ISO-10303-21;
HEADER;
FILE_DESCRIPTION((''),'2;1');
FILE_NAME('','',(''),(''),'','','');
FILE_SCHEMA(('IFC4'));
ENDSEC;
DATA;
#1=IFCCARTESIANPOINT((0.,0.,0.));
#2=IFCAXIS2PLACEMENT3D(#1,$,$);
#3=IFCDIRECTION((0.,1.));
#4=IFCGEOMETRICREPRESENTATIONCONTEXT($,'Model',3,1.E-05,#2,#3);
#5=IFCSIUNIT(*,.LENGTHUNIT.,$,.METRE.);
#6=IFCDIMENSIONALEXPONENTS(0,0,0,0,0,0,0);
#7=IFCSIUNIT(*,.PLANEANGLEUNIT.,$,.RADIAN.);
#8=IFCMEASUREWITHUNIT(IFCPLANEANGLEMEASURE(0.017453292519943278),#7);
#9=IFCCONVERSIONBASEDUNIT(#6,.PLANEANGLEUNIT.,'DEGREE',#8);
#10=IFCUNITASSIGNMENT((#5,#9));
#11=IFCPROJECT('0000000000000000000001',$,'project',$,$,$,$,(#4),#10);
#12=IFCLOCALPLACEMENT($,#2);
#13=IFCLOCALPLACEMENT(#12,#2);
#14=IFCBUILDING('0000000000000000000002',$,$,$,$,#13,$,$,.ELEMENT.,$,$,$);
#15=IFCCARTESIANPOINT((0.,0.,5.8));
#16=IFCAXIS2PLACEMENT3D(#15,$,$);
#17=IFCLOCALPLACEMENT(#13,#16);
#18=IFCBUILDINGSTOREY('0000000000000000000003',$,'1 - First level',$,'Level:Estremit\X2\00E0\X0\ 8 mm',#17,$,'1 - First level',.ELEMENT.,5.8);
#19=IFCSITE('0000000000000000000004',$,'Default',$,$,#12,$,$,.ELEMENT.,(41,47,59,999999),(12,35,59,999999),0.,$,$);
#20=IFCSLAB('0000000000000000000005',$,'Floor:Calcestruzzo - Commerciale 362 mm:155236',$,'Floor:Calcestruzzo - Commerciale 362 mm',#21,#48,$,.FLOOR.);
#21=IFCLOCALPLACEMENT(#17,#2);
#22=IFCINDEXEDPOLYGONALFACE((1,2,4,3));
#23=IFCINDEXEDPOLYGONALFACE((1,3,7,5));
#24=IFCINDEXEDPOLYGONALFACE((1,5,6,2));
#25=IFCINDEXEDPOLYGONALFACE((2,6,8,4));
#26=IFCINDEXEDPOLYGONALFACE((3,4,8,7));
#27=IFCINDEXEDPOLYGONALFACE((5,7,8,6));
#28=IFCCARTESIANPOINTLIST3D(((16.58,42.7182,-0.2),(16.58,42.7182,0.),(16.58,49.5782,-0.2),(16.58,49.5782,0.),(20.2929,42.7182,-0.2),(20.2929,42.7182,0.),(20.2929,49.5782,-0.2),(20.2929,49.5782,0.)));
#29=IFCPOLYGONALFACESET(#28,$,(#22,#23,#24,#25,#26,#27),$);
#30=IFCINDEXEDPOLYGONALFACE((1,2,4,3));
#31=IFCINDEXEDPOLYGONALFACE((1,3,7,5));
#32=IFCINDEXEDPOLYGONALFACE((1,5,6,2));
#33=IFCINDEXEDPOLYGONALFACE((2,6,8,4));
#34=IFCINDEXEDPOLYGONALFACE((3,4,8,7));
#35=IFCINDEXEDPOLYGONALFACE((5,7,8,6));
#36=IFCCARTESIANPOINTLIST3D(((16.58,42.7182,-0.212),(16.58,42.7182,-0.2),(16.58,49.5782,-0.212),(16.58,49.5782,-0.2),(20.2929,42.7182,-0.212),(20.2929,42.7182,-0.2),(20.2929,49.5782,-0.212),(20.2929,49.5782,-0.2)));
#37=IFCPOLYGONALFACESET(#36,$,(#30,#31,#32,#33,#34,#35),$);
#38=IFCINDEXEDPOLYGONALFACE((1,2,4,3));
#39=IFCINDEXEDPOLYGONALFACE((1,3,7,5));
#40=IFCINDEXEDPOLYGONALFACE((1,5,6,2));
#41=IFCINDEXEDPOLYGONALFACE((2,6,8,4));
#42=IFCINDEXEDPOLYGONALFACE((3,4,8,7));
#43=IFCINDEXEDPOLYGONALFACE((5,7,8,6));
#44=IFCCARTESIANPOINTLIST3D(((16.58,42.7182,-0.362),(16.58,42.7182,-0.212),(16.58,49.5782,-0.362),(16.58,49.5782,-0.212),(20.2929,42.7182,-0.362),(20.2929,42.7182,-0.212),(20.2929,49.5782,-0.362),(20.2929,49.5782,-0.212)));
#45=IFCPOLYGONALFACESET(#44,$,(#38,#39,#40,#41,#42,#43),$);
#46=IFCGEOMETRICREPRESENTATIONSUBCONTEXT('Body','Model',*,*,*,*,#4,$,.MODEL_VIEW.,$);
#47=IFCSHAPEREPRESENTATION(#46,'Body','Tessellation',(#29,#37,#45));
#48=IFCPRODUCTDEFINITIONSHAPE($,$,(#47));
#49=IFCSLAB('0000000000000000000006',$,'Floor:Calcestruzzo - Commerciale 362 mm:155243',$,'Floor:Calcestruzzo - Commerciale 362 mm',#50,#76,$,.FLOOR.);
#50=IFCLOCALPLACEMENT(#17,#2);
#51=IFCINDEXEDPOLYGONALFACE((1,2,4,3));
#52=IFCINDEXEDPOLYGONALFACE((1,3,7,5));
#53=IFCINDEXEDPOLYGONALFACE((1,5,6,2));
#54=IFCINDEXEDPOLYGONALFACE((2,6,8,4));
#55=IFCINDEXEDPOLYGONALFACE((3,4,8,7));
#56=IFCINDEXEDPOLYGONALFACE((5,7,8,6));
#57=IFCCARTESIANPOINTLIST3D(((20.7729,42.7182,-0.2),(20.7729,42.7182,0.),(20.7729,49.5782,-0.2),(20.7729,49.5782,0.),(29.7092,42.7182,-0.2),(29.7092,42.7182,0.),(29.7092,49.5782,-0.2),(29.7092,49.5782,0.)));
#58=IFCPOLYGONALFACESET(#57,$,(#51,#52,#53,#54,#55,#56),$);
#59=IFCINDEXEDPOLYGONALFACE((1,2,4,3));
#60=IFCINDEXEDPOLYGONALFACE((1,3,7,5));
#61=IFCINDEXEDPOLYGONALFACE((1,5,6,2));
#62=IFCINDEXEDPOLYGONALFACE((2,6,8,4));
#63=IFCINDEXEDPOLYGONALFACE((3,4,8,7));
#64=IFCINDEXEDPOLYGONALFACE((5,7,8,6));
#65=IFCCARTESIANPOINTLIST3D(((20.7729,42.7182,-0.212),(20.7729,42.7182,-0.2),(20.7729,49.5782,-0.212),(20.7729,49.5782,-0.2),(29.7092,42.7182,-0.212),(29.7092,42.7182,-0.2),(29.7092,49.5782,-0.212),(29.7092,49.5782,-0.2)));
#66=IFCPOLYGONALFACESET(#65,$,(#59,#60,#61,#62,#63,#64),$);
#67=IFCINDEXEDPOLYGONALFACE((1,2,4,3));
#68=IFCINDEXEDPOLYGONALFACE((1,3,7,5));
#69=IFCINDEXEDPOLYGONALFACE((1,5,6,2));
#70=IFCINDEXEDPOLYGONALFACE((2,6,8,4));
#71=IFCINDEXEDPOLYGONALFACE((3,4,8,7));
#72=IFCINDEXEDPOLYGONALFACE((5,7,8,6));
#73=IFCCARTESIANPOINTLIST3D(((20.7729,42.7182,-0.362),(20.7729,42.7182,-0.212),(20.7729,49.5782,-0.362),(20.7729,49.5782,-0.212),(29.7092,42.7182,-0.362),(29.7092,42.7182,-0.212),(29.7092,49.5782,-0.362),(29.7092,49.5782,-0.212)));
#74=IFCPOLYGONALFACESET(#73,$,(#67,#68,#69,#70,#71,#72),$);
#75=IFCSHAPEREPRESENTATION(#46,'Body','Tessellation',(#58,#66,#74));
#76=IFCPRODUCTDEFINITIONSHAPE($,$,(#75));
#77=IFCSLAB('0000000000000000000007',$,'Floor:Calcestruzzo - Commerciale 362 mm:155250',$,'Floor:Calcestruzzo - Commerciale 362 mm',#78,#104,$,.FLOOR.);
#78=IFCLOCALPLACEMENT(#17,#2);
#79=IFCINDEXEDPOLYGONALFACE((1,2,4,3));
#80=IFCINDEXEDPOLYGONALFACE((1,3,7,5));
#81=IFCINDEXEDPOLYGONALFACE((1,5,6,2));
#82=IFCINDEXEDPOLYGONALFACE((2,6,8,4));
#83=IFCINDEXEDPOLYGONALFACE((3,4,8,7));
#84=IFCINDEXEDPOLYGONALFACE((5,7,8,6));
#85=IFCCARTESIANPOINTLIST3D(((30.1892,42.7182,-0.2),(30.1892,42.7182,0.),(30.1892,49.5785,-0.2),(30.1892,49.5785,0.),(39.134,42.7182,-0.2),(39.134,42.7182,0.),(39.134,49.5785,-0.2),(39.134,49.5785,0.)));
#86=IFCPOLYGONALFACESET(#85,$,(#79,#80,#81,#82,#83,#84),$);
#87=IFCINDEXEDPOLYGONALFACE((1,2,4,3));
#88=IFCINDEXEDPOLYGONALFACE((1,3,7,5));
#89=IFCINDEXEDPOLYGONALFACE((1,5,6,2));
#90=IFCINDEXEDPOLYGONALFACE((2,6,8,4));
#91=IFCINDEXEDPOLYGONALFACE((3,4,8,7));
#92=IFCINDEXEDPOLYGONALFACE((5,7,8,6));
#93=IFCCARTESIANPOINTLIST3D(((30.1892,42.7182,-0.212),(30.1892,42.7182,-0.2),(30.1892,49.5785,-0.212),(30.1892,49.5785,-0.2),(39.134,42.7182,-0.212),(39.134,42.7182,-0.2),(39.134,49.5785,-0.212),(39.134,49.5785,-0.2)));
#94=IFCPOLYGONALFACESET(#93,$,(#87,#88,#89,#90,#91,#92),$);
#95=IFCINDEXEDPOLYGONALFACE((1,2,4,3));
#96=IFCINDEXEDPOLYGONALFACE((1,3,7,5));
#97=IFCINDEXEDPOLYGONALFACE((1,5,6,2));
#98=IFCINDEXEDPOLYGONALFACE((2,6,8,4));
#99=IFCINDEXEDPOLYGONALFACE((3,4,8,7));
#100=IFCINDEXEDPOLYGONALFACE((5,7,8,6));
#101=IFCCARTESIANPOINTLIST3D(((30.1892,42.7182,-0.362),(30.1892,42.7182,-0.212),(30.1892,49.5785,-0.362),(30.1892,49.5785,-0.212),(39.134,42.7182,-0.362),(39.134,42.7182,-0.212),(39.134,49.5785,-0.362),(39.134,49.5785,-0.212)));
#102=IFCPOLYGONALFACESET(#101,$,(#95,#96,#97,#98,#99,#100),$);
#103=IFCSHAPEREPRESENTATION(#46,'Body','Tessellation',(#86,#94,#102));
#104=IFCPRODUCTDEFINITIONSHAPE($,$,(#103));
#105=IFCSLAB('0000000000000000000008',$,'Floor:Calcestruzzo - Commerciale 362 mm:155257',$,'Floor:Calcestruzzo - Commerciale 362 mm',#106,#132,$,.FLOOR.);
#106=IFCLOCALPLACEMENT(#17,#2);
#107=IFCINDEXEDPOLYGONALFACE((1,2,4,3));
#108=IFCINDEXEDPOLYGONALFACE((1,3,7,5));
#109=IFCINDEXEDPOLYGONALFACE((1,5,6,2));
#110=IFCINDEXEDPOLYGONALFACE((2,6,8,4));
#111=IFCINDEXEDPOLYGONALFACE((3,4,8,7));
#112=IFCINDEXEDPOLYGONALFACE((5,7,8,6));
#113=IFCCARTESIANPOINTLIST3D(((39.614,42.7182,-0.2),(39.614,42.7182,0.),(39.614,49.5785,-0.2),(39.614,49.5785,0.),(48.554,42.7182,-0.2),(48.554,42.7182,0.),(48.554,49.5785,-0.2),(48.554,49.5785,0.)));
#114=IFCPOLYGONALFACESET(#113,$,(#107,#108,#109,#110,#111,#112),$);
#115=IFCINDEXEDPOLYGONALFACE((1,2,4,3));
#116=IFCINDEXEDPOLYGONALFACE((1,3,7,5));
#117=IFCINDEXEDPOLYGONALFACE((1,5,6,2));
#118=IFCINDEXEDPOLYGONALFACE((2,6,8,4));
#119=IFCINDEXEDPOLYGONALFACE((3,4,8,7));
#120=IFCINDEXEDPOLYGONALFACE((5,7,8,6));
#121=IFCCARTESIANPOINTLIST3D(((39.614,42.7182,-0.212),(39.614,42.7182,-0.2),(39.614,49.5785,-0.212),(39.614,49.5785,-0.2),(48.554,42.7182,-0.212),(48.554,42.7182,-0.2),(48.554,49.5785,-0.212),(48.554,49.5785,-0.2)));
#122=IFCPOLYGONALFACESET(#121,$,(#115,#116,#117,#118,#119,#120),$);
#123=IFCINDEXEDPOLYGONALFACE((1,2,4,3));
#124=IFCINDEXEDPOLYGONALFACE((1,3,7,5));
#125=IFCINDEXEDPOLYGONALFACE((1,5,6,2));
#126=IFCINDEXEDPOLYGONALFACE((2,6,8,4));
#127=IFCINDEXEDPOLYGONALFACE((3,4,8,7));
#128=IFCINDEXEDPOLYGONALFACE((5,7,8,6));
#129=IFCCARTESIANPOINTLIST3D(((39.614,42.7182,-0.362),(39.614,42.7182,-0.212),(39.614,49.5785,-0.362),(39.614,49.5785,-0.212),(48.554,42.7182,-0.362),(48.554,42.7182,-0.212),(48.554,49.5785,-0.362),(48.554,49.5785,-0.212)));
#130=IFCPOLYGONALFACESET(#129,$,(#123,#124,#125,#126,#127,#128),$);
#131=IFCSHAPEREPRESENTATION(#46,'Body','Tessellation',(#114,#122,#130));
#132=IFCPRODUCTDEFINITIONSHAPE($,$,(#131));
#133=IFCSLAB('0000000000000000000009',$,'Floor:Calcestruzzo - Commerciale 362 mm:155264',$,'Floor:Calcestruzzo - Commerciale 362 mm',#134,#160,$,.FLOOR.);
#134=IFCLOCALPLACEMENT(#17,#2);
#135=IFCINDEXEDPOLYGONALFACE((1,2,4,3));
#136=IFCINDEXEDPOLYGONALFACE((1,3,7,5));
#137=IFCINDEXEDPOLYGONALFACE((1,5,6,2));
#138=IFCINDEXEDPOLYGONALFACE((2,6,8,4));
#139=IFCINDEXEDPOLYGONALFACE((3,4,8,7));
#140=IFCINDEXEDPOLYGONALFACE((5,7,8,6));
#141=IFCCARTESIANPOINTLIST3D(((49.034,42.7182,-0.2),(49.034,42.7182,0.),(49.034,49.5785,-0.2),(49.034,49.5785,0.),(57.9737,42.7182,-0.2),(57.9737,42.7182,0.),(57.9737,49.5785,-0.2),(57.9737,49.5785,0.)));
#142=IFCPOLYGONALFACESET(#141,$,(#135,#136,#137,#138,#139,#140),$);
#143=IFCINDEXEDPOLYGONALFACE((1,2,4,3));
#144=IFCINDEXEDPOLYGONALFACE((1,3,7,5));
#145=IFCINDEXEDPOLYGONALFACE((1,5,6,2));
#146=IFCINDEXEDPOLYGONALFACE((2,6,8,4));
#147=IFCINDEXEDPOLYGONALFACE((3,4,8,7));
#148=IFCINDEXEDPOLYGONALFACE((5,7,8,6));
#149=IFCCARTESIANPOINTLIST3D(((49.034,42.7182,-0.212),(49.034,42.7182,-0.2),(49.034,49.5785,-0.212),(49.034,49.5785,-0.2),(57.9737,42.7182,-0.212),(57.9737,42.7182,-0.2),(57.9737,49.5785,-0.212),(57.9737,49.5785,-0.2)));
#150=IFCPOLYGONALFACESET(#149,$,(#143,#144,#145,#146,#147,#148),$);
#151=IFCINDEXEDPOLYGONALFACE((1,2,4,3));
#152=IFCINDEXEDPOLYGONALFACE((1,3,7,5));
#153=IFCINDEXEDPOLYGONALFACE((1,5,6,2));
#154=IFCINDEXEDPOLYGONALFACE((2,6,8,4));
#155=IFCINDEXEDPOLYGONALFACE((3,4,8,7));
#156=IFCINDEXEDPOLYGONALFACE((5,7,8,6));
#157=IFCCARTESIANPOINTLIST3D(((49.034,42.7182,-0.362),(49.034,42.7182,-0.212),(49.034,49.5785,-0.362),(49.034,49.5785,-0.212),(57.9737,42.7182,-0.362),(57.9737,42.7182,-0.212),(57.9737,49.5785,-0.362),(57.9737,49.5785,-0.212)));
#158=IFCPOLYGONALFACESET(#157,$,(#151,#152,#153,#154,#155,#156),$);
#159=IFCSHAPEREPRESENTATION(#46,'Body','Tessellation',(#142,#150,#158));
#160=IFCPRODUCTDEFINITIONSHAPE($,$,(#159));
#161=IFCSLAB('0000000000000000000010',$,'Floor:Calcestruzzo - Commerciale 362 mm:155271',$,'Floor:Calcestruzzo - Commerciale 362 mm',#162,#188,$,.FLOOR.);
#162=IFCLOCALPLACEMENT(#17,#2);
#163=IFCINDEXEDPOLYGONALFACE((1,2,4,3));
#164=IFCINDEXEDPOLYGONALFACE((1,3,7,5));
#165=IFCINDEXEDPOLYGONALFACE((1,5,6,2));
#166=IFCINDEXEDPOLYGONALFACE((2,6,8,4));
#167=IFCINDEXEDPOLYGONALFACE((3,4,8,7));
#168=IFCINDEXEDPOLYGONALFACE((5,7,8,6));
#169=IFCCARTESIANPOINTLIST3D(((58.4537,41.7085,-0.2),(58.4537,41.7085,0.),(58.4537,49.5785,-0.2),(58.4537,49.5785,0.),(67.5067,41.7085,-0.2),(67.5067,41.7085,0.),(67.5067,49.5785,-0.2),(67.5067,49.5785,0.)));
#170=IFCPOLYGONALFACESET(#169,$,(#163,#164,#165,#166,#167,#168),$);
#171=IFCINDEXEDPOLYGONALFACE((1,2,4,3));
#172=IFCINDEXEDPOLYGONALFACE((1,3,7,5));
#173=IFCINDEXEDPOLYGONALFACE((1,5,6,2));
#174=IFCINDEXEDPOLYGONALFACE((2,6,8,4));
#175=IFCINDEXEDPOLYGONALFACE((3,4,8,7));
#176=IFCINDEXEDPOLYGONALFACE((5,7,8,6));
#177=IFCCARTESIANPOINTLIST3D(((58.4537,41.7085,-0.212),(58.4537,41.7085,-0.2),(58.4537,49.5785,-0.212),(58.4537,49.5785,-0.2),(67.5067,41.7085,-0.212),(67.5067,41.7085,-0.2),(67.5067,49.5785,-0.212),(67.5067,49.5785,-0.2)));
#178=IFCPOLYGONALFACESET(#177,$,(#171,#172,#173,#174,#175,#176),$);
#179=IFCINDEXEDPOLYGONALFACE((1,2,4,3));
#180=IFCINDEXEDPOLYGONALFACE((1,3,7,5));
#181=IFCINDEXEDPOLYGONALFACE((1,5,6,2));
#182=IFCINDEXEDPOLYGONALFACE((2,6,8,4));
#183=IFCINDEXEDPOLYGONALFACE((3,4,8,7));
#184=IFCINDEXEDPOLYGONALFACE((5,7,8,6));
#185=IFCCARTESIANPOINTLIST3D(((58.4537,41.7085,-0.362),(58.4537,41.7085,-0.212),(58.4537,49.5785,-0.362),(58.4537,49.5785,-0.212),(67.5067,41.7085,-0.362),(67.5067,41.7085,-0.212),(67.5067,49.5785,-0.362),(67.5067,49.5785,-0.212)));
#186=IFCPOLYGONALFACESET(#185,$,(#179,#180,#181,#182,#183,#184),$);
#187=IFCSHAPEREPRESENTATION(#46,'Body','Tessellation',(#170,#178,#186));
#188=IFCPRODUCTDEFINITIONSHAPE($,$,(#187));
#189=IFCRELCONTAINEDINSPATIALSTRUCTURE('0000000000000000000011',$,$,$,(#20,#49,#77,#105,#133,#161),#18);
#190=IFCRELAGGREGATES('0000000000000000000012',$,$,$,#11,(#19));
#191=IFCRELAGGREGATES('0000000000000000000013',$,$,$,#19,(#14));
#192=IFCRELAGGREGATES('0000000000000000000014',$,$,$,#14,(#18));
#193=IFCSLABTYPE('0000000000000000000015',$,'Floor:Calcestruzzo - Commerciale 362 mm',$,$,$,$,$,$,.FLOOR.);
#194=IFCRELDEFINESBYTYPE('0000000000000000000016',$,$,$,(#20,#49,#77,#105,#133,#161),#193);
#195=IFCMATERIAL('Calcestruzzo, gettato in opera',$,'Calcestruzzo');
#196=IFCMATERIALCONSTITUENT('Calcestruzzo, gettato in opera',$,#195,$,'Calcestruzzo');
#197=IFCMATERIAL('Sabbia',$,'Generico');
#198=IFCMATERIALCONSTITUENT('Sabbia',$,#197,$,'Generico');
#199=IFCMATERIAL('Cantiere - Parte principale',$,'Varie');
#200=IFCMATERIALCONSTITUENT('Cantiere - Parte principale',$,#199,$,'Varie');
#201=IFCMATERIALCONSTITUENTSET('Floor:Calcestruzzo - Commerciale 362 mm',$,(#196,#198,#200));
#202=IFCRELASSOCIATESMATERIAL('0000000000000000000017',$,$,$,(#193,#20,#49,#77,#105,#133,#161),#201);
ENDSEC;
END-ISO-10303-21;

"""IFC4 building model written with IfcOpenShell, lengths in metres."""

from ifc_helpers import new_model, entity, si_unit, converted_unit, direction, frame, origin, place, context, subcontext, project, spatial, indexed_curve, outline, extrude, material, constituent, constituent_set, type_object, element, save


model = new_model("IFC4")

# Units and contexts
model_context = context("Model", 3, precision=1e-05, world=origin(), true_north=direction((0.0, 1.0)))
body_context = subcontext(model_context, "Body", "Model", "MODEL_VIEW")
ifc_project = project(units=[si_unit("LENGTHUNIT", "METRE"), converted_unit("PLANEANGLEUNIT", "DEGREE", entity("IfcPlaneAngleMeasure", 0.017453292519943278), si_unit("PLANEANGLEUNIT", "RADIAN"), dimensions=[0, 0, 0, 0, 0, 0, 0])], contexts=[model_context])

# Site, building, storey
site_placement = place(None, origin())
site = spatial("IfcSite", under=ifc_project, at=site_placement, Name="Default", CompositionType="ELEMENT", RefLatitude=(41, 47, 59, 999999), RefLongitude=(12, 35, 59, 999999), RefElevation=0.0)
building_placement = place(site_placement, origin())
building = spatial("IfcBuilding", under=site, at=building_placement, CompositionType="ELEMENT")
storey_placement = place(building_placement, frame((0.0, 0.0, 5.8)))
storey = spatial("IfcBuildingStorey", under=building, at=storey_placement, Name="1 - First level", ObjectType="Level:Estremità 8 mm", LongName="1 - First level", CompositionType="ELEMENT", Elevation=5.8)

# Slabs
ifc_material_1 = material(Name="Calcestruzzo, gettato in opera", Category="Calcestruzzo")
ifc_constituent_1 = constituent(ifc_material_1, Name="Calcestruzzo, gettato in opera", Category="Calcestruzzo")
ifc_material_2 = material(Name="Sabbia", Category="Generico")
ifc_constituent_2 = constituent(ifc_material_2, Name="Sabbia", Category="Generico")
ifc_material_3 = material(Name="Cantiere - Parte principale", Category="Varie")
ifc_constituent_3 = constituent(ifc_material_3, Name="Cantiere - Parte principale", Category="Varie")
ifc_constituent_set = constituent_set(constituents=[ifc_constituent_1, ifc_constituent_2, ifc_constituent_3], Name="Floor:Calcestruzzo - Commerciale 362 mm")
slab_type = type_object("IfcSlabType", Name="Floor:Calcestruzzo - Commerciale 362 mm", PredefinedType="FLOOR", material=ifc_constituent_set)
slab_1_placement = place(storey_placement, origin())
element("IfcSlab", 1, at=slab_1_placement, inside=storey, type_object=slab_type, material=ifc_constituent_set, Name="Floor:Calcestruzzo - Commerciale 362 mm:155236", ObjectType="Floor:Calcestruzzo - Commerciale 362 mm", PredefinedType="FLOOR", context=body_context, shape_type="SweptSolid", body=[
    extrude(outline(indexed_curve([(-1.8565, -3.43), (1.8565, -3.43), (1.8565, 3.43), (-1.8565, 3.43), (-1.8565, -3.43)], self_intersect=False)), frame((18.4365, 46.1482, -0.2), z_axis=(0.0, 0.0, 1.0), x_axis=(-1.0, 0.0, 0.0)), (0.0, 0.0, 1.0), 0.2),
    extrude(outline(indexed_curve([(-1.8565, -3.43), (1.8565, -3.43), (1.8565, 3.43), (-1.8565, 3.43), (-1.8565, -3.43)], self_intersect=False)), frame((18.4365, 46.1482, -0.212), z_axis=(0.0, 0.0, 1.0), x_axis=(-1.0, 0.0, 0.0)), (0.0, 0.0, 1.0), 0.012),
    extrude(outline(indexed_curve([(-1.8565, -3.43), (1.8565, -3.43), (1.8565, 3.43), (-1.8565, 3.43), (-1.8565, -3.43)], self_intersect=False)), frame((18.4365, 46.1482, -0.362), z_axis=(0.0, 0.0, 1.0), x_axis=(-1.0, 0.0, 0.0)), (0.0, 0.0, 1.0), 0.15),
])
slab_2_placement = place(storey_placement, origin())
element("IfcSlab", 2, at=slab_2_placement, inside=storey, type_object=slab_type, material=ifc_constituent_set, Name="Floor:Calcestruzzo - Commerciale 362 mm:155243", ObjectType="Floor:Calcestruzzo - Commerciale 362 mm", PredefinedType="FLOOR", context=body_context, shape_type="SweptSolid", body=[
    extrude(outline(indexed_curve([(-3.43, -4.4681), (3.43, -4.4681), (3.43, 4.4681), (-3.43, 4.4681), (-3.43, -4.4681)], self_intersect=False)), frame((25.2411, 46.1482, -0.2), z_axis=(0.0, 0.0, 1.0), x_axis=(0.0, -1.0, 0.0)), (0.0, 0.0, 1.0), 0.2),
    extrude(outline(indexed_curve([(-3.43, -4.4681), (3.43, -4.4681), (3.43, 4.4681), (-3.43, 4.4681), (-3.43, -4.4681)], self_intersect=False)), frame((25.2411, 46.1482, -0.212), z_axis=(0.0, 0.0, 1.0), x_axis=(0.0, -1.0, 0.0)), (0.0, 0.0, 1.0), 0.012),
    extrude(outline(indexed_curve([(-3.43, -4.4681), (3.43, -4.4681), (3.43, 4.4681), (-3.43, 4.4681), (-3.43, -4.4681)], self_intersect=False)), frame((25.2411, 46.1482, -0.362), z_axis=(0.0, 0.0, 1.0), x_axis=(0.0, -1.0, 0.0)), (0.0, 0.0, 1.0), 0.15),
])
slab_3_placement = place(storey_placement, origin())
element("IfcSlab", 3, at=slab_3_placement, inside=storey, type_object=slab_type, material=ifc_constituent_set, Name="Floor:Calcestruzzo - Commerciale 362 mm:155250", ObjectType="Floor:Calcestruzzo - Commerciale 362 mm", PredefinedType="FLOOR", context=body_context, shape_type="SweptSolid", body=[
    extrude(outline(indexed_curve([(-3.4302, -4.4724), (3.4302, -4.4724), (3.4302, 4.4724), (-3.4302, 4.4724), (-3.4302, -4.4724)], self_intersect=False)), frame((34.6616, 46.1483, -0.2), z_axis=(0.0, 0.0, 1.0), x_axis=(0.0, -1.0, 0.0)), (0.0, 0.0, 1.0), 0.2),
    extrude(outline(indexed_curve([(-3.4302, -4.4724), (3.4302, -4.4724), (3.4302, 4.4724), (-3.4302, 4.4724), (-3.4302, -4.4724)], self_intersect=False)), frame((34.6616, 46.1483, -0.212), z_axis=(0.0, 0.0, 1.0), x_axis=(0.0, -1.0, 0.0)), (0.0, 0.0, 1.0), 0.012),
    extrude(outline(indexed_curve([(-3.4302, -4.4724), (3.4302, -4.4724), (3.4302, 4.4724), (-3.4302, 4.4724), (-3.4302, -4.4724)], self_intersect=False)), frame((34.6616, 46.1483, -0.362), z_axis=(0.0, 0.0, 1.0), x_axis=(0.0, -1.0, 0.0)), (0.0, 0.0, 1.0), 0.15),
])
slab_4_placement = place(storey_placement, origin())
element("IfcSlab", 4, at=slab_4_placement, inside=storey, type_object=slab_type, material=ifc_constituent_set, Name="Floor:Calcestruzzo - Commerciale 362 mm:155257", ObjectType="Floor:Calcestruzzo - Commerciale 362 mm", PredefinedType="FLOOR", context=body_context, shape_type="SweptSolid", body=[
    extrude(outline(indexed_curve([(-3.4302, -4.47), (3.4302, -4.47), (3.4302, 4.47), (-3.4302, 4.47), (-3.4302, -4.47)], self_intersect=False)), frame((44.084, 46.1483, -0.2), z_axis=(0.0, 0.0, 1.0), x_axis=(0.0, -1.0, 0.0)), (0.0, 0.0, 1.0), 0.2),
    extrude(outline(indexed_curve([(-3.4302, -4.47), (3.4302, -4.47), (3.4302, 4.47), (-3.4302, 4.47), (-3.4302, -4.47)], self_intersect=False)), frame((44.084, 46.1483, -0.212), z_axis=(0.0, 0.0, 1.0), x_axis=(0.0, -1.0, 0.0)), (0.0, 0.0, 1.0), 0.012),
    extrude(outline(indexed_curve([(-3.4302, -4.47), (3.4302, -4.47), (3.4302, 4.47), (-3.4302, 4.47), (-3.4302, -4.47)], self_intersect=False)), frame((44.084, 46.1483, -0.362), z_axis=(0.0, 0.0, 1.0), x_axis=(0.0, -1.0, 0.0)), (0.0, 0.0, 1.0), 0.15),
])
slab_5_placement = place(storey_placement, origin())
element("IfcSlab", 5, at=slab_5_placement, inside=storey, type_object=slab_type, material=ifc_constituent_set, Name="Floor:Calcestruzzo - Commerciale 362 mm:155264", ObjectType="Floor:Calcestruzzo - Commerciale 362 mm", PredefinedType="FLOOR", context=body_context, shape_type="SweptSolid", body=[
    extrude(outline(indexed_curve([(-3.4302, -4.4698), (3.4302, -4.4698), (3.4302, 4.4698), (-3.4302, 4.4698), (-3.4302, -4.4698)], self_intersect=False)), frame((53.5038, 46.1483, -0.2), z_axis=(0.0, 0.0, 1.0), x_axis=(0.0, -1.0, 0.0)), (0.0, 0.0, 1.0), 0.2),
    extrude(outline(indexed_curve([(-3.4302, -4.4698), (3.4302, -4.4698), (3.4302, 4.4698), (-3.4302, 4.4698), (-3.4302, -4.4698)], self_intersect=False)), frame((53.5038, 46.1483, -0.212), z_axis=(0.0, 0.0, 1.0), x_axis=(0.0, -1.0, 0.0)), (0.0, 0.0, 1.0), 0.012),
    extrude(outline(indexed_curve([(-3.4302, -4.4698), (3.4302, -4.4698), (3.4302, 4.4698), (-3.4302, 4.4698), (-3.4302, -4.4698)], self_intersect=False)), frame((53.5038, 46.1483, -0.362), z_axis=(0.0, 0.0, 1.0), x_axis=(0.0, -1.0, 0.0)), (0.0, 0.0, 1.0), 0.15),
])
slab_6_placement = place(storey_placement, origin())
element("IfcSlab", 6, at=slab_6_placement, inside=storey, type_object=slab_type, material=ifc_constituent_set, Name="Floor:Calcestruzzo - Commerciale 362 mm:155271", ObjectType="Floor:Calcestruzzo - Commerciale 362 mm", PredefinedType="FLOOR", context=body_context, shape_type="SweptSolid", body=[
    extrude(outline(indexed_curve([(-4.5265, -3.935), (4.5265, -3.935), (4.5265, 3.935), (-4.5265, 3.935), (-4.5265, -3.935)], self_intersect=False)), frame((62.9802, 45.6435, -0.2)), (0.0, 0.0, 1.0), 0.2),
    extrude(outline(indexed_curve([(-4.5265, -3.935), (4.5265, -3.935), (4.5265, 3.935), (-4.5265, 3.935), (-4.5265, -3.935)], self_intersect=False)), frame((62.9802, 45.6435, -0.212)), (0.0, 0.0, 1.0), 0.012),
    extrude(outline(indexed_curve([(-4.5265, -3.935), (4.5265, -3.935), (4.5265, 3.935), (-4.5265, 3.935), (-4.5265, -3.935)], self_intersect=False)), frame((62.9802, 45.6435, -0.362)), (0.0, 0.0, 1.0), 0.15),
])

save(model, "model.ifc")
